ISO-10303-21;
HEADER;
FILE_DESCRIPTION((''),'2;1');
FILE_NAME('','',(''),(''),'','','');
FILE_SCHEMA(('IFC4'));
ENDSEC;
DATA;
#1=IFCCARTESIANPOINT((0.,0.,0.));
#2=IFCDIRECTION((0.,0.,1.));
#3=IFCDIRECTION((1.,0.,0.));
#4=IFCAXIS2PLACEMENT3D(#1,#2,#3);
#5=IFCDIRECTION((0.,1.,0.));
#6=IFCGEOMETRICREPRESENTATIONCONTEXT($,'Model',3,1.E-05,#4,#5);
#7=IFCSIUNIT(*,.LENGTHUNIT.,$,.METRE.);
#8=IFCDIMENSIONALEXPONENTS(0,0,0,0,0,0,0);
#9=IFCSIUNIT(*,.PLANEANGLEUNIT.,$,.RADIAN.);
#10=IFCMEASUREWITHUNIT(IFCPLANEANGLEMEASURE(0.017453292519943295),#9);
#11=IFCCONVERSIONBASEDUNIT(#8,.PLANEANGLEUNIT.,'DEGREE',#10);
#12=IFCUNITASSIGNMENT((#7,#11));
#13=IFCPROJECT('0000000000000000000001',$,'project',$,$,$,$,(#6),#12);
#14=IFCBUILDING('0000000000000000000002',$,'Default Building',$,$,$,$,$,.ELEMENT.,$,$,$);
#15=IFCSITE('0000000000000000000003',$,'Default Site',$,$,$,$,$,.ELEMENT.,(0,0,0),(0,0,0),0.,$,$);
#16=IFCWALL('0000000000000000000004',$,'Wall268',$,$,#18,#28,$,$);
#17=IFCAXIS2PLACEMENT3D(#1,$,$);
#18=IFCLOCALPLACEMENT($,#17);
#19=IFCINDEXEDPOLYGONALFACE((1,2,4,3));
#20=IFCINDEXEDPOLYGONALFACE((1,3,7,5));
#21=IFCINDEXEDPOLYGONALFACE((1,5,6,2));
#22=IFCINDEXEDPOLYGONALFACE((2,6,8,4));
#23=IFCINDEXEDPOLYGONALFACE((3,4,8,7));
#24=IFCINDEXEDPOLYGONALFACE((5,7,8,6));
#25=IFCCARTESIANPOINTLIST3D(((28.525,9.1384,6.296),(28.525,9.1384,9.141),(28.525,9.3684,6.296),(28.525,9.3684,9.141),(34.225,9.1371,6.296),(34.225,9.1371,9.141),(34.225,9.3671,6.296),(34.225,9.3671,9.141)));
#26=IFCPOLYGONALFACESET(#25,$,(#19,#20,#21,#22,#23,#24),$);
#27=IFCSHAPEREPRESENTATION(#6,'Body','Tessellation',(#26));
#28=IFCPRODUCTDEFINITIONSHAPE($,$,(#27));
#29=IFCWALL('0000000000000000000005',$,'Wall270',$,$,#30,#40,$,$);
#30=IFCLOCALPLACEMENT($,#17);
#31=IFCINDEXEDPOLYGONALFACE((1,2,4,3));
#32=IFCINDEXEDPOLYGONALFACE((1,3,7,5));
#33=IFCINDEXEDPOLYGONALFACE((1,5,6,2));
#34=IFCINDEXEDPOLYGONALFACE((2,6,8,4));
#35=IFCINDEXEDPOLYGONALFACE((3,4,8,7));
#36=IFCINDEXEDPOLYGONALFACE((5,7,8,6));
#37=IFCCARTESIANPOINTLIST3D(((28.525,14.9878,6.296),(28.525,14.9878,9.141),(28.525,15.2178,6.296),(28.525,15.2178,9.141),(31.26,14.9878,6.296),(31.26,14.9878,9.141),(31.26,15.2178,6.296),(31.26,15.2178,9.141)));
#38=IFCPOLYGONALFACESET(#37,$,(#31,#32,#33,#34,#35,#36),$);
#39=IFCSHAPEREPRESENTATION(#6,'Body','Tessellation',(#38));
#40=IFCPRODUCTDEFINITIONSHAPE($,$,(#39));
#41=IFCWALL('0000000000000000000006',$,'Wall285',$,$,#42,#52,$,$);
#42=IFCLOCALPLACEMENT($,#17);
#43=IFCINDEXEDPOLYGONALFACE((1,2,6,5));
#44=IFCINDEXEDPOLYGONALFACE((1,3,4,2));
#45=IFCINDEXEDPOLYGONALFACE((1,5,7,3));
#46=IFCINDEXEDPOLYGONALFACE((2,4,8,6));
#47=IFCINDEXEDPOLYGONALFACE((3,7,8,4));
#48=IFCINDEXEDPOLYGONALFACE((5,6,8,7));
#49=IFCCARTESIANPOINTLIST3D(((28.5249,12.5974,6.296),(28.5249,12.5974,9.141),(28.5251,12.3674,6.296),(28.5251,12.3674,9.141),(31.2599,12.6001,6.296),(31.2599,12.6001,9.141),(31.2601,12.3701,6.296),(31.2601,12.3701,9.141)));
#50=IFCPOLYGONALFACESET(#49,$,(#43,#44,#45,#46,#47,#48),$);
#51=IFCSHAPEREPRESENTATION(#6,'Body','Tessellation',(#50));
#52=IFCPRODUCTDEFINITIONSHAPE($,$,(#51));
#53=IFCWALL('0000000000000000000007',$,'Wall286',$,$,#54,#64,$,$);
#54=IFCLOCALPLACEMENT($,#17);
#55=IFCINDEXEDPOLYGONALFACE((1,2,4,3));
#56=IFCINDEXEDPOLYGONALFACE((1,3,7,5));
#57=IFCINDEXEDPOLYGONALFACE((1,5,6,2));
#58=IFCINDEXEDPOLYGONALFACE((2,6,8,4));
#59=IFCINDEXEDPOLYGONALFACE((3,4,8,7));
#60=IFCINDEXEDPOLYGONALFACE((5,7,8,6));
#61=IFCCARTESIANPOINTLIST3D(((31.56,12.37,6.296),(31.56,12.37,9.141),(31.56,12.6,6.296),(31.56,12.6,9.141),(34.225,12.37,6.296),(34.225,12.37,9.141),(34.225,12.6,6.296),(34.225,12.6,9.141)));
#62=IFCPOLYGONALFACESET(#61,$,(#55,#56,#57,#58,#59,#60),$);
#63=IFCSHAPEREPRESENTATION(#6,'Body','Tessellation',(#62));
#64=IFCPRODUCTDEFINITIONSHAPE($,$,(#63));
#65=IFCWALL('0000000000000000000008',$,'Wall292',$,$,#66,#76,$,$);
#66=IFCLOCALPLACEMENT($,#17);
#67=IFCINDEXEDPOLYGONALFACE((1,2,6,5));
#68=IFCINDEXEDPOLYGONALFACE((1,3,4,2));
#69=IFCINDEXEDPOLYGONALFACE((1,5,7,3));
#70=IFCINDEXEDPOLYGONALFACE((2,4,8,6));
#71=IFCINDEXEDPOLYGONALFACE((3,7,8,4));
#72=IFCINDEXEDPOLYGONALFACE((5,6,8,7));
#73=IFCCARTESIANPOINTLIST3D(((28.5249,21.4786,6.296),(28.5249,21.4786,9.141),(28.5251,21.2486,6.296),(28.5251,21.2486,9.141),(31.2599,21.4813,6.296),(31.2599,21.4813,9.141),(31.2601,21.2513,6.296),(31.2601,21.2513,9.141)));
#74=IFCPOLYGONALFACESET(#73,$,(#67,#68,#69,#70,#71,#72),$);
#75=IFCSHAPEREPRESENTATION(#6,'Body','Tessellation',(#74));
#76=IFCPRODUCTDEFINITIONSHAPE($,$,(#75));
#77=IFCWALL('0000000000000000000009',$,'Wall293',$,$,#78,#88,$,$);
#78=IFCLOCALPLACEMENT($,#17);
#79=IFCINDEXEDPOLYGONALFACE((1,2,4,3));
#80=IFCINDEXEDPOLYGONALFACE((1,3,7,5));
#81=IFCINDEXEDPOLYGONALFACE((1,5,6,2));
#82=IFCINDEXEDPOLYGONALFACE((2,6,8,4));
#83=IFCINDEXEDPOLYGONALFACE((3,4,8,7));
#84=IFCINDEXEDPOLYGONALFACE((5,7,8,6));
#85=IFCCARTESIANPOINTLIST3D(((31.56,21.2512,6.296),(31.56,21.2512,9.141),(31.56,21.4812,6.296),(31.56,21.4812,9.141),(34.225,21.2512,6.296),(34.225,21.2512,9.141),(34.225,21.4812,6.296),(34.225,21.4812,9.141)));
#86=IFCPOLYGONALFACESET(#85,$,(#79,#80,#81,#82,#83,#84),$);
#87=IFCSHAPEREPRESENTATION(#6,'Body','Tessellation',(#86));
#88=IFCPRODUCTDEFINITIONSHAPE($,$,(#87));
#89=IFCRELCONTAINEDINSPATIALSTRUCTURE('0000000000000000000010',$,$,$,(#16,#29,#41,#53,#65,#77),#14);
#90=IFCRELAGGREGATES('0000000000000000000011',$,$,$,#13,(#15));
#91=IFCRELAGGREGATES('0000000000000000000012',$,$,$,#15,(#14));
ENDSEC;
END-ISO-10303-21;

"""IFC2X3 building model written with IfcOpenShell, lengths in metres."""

from ifc_helpers import new_model, entity, si_unit, converted_unit, direction, frame, frame_2d, origin_with_axes, place, context, project, spatial, rectangle, extrude, element, save


model = new_model("IFC2X3")

# Units and contexts
model_context = context("Model", 3, precision=1e-05, world=origin_with_axes(), true_north=direction((0.0, 1.0, 0.0)))
ifc_project = project(units=[si_unit("LENGTHUNIT", "METRE"), converted_unit("PLANEANGLEUNIT", "DEGREE", entity("IfcPlaneAngleMeasure", 0.017453292519943295), si_unit("PLANEANGLEUNIT", "RADIAN"), dimensions=[0, 0, 0, 0, 0, 0, 0])], contexts=[model_context])

# Site, building
site = spatial("IfcSite", under=ifc_project, Name="Default Site", CompositionType="ELEMENT", RefLatitude=(0, 0, 0), RefLongitude=(0, 0, 0), RefElevation=0.0)
building = spatial("IfcBuilding", under=site, Name="Default Building", CompositionType="ELEMENT")

# Walls
placement = place(None, origin_with_axes())
element("IfcWall", 1, at=placement, inside=building, Name="Wall268", context=model_context, shape_type="SweptSolid", body=[
    extrude(rectangle(XDim=5.7, YDim=0.23, at=frame_2d((0.0, 0.0), x_axis=(1.0, -0.000224, 0.0))), frame((31.375, 9.2528, 6.296), z_axis=(0.0, 0.0, 1.0), x_axis=(1.0, 0.0, 0.0)), (0.0, 0.0, 1.0), 2.845),
])
element("IfcWall", 2, at=placement, inside=building, Name="Wall270", context=model_context, shape_type="SweptSolid", body=[
    extrude(rectangle(XDim=2.735, YDim=0.23, at=frame_2d((0.0, 0.0), x_axis=(-1.0, 0.0, 0.0))), frame((29.8925, 15.1028, 6.296), z_axis=(0.0, 0.0, 1.0), x_axis=(1.0, 0.0, 0.0)), (0.0, 0.0, 1.0), 2.845),
])
element("IfcWall", 3, at=placement, inside=building, Name="Wall285", context=model_context, shape_type="SweptSolid", body=[
    extrude(rectangle(XDim=2.735, YDim=0.23, at=frame_2d((0.0, 0.0), x_axis=(-1.0, -0.00098, 0.0))), frame((29.8925, 12.4838, 6.296), z_axis=(0.0, 0.0, 1.0), x_axis=(1.0, 0.0, 0.0)), (0.0, 0.0, 1.0), 2.845),
])
element("IfcWall", 4, at=placement, inside=building, Name="Wall286", context=model_context, shape_type="SweptSolid", body=[
    extrude(rectangle(XDim=2.665, YDim=0.23, at=frame_2d((0.0, 0.0), x_axis=(-1.0, 0.0, 0.0))), frame((32.8925, 12.485, 6.296), z_axis=(0.0, 0.0, 1.0), x_axis=(1.0, 0.0, 0.0)), (0.0, 0.0, 1.0), 2.845),
])
element("IfcWall", 5, at=placement, inside=building, Name="Wall292", context=model_context, shape_type="SweptSolid", body=[
    extrude(rectangle(XDim=2.735, YDim=0.23, at=frame_2d((0.0, 0.0), x_axis=(-1.0, -0.00098, 0.0))), frame((29.8925, 21.3649, 6.296), z_axis=(0.0, 0.0, 1.0), x_axis=(1.0, 0.0, 0.0)), (0.0, 0.0, 1.0), 2.845),
])
element("IfcWall", 6, at=placement, inside=building, Name="Wall293", context=model_context, shape_type="SweptSolid", body=[
    extrude(rectangle(XDim=2.665, YDim=0.23, at=frame_2d((0.0, 0.0), x_axis=(-1.0, 0.0, 0.0))), frame((32.8925, 21.3662, 6.296), z_axis=(0.0, 0.0, 1.0), x_axis=(1.0, 0.0, 0.0)), (0.0, 0.0, 1.0), 2.845),
])

save(model, "model.ifc")
